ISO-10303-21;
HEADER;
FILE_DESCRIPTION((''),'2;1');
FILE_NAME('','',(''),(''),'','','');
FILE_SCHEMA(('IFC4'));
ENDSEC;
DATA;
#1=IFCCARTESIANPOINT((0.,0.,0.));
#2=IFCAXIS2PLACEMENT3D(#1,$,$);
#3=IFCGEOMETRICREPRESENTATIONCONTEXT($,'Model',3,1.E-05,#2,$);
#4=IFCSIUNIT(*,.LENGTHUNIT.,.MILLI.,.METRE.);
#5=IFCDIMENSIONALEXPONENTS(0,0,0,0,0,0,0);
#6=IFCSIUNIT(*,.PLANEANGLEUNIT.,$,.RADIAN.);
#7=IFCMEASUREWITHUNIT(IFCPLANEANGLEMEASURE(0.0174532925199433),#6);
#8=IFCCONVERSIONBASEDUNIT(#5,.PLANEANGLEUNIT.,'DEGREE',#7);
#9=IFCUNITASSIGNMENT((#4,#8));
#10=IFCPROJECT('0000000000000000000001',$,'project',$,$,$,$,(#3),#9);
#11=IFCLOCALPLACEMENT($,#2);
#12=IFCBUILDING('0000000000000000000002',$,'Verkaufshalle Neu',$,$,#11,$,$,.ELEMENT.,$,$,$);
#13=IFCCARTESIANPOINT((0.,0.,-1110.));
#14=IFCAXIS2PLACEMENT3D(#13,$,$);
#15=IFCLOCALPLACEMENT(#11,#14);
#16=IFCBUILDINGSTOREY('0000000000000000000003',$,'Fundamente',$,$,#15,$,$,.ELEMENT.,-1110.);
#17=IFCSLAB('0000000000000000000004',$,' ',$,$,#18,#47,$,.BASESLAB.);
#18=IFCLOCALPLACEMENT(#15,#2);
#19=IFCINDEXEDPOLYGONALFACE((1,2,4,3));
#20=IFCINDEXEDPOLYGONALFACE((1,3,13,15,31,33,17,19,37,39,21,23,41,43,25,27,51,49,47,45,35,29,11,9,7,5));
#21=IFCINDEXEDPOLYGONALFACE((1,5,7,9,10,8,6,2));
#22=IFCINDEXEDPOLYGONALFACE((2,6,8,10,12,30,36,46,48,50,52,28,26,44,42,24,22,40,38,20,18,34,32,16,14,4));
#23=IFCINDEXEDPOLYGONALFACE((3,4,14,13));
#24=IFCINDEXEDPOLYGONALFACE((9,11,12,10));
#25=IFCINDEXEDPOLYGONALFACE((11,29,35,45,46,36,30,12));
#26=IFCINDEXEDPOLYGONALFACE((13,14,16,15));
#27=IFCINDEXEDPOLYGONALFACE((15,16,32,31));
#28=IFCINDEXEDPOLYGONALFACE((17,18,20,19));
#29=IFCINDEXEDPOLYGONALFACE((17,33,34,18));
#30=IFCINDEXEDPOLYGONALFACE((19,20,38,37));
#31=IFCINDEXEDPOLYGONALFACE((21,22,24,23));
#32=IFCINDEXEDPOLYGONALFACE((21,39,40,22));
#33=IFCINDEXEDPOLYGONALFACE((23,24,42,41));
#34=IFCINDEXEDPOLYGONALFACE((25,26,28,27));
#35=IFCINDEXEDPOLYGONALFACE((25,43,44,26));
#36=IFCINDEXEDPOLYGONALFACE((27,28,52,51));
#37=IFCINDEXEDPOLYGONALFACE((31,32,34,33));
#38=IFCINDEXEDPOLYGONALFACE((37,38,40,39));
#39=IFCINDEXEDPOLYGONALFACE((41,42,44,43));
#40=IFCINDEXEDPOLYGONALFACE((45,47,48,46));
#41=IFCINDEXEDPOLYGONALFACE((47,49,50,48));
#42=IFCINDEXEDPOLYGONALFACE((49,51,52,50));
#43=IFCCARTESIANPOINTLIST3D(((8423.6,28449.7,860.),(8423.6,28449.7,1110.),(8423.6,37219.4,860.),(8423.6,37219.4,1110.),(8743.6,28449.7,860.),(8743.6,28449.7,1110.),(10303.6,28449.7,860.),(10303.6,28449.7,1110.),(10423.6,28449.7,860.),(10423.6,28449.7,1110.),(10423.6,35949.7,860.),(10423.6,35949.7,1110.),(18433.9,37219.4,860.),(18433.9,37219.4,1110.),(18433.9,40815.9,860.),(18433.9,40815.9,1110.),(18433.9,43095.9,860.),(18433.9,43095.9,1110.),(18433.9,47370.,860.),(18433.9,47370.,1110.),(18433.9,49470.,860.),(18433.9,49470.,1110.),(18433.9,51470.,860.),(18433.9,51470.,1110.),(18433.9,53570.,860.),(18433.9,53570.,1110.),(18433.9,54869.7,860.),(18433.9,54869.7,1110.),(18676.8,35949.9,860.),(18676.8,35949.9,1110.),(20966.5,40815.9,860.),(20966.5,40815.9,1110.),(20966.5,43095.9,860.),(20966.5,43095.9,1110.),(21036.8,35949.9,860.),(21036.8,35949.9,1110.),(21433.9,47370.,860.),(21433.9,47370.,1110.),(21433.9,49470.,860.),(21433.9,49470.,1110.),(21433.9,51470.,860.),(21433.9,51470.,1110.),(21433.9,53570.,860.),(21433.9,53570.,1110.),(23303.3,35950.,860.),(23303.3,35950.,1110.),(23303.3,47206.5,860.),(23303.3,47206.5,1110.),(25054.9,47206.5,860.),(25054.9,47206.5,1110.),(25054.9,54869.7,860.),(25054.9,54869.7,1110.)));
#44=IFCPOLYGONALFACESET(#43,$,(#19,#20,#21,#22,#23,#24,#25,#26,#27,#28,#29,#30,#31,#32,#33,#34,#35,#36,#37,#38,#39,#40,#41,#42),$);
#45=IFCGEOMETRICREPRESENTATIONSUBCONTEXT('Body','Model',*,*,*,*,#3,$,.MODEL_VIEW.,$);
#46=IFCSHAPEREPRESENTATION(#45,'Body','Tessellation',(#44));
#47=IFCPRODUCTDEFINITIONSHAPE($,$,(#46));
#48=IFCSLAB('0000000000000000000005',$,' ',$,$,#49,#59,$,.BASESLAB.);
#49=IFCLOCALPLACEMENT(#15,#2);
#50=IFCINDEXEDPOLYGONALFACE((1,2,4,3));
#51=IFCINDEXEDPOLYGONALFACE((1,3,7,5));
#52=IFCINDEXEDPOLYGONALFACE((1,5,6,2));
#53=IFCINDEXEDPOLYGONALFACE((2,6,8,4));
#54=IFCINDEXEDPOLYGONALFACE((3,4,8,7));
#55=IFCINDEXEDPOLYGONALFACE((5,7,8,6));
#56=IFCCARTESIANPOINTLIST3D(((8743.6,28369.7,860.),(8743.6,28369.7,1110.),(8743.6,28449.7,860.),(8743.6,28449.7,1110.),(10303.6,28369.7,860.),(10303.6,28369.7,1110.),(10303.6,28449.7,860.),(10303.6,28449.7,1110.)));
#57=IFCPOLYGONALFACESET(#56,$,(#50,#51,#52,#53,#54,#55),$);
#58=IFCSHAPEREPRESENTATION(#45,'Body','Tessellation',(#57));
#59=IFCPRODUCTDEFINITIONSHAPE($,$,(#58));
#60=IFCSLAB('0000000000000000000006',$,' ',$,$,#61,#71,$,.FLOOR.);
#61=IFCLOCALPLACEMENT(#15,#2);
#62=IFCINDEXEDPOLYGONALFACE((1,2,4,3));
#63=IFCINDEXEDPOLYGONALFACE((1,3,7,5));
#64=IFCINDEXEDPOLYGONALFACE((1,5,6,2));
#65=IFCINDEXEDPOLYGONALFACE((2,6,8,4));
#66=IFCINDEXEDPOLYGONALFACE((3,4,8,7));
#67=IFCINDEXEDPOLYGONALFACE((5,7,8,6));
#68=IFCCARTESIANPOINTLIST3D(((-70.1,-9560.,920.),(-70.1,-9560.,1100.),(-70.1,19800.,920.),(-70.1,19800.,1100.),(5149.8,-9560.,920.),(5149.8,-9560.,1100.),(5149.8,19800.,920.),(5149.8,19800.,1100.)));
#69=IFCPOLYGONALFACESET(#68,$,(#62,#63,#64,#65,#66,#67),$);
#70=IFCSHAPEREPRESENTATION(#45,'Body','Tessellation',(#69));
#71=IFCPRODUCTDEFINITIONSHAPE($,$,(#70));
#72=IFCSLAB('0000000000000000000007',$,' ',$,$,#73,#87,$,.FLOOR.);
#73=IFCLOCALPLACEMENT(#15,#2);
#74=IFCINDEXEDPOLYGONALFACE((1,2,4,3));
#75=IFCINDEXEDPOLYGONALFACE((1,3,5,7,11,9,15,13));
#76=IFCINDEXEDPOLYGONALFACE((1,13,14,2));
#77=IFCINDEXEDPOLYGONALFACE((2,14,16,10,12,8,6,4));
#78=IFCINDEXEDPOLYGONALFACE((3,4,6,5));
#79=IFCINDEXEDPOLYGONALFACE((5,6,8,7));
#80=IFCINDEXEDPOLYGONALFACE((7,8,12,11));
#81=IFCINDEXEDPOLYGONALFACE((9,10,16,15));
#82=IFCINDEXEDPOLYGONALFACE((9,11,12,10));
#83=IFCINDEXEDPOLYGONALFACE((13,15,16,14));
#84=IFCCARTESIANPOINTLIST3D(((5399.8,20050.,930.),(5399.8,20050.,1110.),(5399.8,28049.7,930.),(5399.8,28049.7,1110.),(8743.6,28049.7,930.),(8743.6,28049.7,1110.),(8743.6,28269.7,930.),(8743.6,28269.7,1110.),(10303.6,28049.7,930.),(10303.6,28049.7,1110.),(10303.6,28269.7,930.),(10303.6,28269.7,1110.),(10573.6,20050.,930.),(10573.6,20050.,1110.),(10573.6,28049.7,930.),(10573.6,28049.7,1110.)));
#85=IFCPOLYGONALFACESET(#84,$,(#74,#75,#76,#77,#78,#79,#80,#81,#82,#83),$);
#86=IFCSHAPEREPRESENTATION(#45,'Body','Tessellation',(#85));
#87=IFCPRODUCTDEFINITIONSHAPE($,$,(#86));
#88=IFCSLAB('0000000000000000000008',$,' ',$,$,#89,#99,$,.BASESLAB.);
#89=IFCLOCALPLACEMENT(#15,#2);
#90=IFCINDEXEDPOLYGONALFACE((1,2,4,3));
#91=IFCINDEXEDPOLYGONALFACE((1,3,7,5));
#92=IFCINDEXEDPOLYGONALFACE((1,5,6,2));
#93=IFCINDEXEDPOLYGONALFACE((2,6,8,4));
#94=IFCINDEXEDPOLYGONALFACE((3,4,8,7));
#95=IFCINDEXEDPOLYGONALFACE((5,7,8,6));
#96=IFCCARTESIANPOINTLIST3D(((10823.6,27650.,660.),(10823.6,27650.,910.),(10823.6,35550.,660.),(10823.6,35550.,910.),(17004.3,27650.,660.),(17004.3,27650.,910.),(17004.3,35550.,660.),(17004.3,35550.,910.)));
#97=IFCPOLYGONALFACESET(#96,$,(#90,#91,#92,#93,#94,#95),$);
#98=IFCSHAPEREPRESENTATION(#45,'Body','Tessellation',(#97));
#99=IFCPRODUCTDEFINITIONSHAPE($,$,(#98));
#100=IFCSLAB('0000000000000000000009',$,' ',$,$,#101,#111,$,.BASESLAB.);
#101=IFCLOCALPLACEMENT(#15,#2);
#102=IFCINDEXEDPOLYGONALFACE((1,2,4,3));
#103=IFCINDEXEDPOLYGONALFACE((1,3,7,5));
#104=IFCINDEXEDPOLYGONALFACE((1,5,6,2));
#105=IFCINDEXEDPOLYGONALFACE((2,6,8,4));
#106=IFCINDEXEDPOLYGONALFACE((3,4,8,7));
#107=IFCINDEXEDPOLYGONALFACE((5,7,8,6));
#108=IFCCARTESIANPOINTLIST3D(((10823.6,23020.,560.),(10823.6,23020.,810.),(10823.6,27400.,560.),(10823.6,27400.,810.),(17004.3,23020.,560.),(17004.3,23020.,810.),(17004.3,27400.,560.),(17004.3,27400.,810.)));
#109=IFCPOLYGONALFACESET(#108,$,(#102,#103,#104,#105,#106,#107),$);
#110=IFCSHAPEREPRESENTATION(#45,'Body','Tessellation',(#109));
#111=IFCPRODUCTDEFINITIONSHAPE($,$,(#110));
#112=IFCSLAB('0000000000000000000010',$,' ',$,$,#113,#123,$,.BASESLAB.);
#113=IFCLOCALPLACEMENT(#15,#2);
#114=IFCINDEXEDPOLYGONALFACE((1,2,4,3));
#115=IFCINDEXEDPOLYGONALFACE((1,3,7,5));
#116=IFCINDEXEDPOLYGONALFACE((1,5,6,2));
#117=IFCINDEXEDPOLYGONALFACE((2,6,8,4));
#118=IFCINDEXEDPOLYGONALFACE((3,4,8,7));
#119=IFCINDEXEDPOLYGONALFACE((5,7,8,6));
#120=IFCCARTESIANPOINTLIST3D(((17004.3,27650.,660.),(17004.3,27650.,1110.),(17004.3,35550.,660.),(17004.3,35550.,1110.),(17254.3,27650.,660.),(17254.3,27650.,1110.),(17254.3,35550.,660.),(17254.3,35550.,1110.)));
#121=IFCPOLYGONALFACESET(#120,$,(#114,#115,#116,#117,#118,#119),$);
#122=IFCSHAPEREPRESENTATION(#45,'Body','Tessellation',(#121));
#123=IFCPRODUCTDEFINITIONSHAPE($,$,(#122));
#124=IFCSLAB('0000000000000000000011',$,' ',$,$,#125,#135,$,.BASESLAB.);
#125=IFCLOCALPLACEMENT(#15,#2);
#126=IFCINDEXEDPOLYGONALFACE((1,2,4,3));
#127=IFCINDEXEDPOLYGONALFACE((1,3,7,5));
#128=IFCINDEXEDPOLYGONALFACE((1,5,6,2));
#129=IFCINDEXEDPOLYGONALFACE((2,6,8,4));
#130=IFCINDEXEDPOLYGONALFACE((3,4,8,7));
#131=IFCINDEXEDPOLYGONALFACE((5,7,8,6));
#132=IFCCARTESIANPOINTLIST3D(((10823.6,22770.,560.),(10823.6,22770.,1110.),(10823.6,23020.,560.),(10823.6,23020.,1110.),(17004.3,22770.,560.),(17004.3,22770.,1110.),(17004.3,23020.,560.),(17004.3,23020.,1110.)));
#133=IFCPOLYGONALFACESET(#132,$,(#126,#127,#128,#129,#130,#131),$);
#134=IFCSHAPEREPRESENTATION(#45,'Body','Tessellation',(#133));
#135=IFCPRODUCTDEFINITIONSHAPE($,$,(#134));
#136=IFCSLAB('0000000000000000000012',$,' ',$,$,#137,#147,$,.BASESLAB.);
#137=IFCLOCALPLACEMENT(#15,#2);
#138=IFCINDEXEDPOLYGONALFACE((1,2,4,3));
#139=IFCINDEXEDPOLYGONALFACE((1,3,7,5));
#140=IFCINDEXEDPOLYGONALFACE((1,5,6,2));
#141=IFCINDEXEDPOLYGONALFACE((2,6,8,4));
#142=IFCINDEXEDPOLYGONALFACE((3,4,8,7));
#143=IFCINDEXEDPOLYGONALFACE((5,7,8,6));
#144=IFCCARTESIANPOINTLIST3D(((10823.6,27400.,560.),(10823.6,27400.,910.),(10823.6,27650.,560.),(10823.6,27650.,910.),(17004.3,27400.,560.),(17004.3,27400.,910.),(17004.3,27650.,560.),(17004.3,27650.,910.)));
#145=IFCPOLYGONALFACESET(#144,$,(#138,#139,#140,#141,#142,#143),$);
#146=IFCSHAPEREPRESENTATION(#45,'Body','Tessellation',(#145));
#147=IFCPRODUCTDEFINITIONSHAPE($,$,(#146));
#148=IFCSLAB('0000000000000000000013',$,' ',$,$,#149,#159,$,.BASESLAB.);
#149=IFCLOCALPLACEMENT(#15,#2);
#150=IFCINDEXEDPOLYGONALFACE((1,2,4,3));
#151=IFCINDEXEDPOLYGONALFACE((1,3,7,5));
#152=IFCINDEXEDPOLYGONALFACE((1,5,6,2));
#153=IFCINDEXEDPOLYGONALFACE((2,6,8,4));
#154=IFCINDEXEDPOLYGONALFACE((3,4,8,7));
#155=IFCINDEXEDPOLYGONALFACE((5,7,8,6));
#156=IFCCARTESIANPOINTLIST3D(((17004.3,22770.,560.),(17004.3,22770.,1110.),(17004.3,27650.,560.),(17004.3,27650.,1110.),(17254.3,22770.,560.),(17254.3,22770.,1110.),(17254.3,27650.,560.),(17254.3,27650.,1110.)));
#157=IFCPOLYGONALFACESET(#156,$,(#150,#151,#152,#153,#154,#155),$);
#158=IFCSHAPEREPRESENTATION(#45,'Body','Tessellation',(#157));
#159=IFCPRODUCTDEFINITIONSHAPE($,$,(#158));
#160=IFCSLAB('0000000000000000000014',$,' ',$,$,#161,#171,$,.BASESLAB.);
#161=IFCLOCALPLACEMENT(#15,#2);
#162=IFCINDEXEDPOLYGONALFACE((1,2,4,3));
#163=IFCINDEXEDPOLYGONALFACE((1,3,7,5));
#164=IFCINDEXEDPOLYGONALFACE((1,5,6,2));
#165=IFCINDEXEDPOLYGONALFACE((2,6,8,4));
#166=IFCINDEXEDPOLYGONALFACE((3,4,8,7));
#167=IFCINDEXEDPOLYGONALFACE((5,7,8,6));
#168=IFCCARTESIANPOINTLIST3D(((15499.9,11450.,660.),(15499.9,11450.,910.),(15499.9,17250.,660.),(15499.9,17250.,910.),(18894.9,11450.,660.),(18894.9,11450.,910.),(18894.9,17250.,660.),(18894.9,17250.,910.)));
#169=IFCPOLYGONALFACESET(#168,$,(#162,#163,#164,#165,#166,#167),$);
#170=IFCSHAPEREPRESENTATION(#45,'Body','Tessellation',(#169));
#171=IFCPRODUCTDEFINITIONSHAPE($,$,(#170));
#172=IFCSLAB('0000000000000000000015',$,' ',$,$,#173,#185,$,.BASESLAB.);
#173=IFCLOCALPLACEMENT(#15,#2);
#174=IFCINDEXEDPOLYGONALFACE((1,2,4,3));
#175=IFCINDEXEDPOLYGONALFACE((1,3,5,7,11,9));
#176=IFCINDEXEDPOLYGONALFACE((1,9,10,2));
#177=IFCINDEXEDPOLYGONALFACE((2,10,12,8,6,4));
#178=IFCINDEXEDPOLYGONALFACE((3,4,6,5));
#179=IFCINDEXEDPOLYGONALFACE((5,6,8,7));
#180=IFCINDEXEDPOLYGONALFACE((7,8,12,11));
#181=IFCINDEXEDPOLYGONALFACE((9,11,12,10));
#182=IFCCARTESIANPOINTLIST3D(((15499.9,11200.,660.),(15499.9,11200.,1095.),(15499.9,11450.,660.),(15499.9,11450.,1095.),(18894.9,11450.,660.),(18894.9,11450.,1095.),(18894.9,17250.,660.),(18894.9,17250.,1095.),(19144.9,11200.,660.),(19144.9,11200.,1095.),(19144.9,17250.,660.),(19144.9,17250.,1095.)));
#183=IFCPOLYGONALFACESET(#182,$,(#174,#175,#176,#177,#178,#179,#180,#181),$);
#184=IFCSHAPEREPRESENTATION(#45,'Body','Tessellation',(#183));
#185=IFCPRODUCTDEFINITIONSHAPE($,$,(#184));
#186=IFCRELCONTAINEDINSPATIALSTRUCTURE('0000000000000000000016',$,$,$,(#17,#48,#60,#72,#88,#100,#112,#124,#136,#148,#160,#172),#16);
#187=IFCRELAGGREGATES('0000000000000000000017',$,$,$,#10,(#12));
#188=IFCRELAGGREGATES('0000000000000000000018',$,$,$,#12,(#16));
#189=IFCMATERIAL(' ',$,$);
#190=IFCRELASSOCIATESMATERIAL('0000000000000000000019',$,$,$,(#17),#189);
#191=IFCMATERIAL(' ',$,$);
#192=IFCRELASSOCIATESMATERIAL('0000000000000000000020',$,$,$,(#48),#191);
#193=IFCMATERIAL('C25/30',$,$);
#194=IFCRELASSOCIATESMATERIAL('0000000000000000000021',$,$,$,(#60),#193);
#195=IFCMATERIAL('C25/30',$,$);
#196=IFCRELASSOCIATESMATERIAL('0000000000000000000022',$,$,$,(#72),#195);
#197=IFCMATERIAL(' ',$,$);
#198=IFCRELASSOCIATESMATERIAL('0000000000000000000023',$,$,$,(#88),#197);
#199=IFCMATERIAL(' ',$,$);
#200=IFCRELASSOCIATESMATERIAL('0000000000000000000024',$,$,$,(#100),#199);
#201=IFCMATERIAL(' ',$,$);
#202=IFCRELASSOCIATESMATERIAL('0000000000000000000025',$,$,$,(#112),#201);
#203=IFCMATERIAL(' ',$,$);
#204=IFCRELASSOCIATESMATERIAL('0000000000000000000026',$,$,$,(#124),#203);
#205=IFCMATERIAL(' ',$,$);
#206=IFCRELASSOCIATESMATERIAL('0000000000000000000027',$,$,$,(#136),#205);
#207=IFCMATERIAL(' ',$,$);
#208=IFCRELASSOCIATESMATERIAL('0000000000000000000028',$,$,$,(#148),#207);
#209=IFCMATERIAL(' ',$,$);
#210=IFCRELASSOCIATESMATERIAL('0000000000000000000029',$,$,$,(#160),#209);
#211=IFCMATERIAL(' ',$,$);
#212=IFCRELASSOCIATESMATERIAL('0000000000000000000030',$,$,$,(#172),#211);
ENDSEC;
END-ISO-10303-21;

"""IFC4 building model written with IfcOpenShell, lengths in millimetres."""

from ifc_helpers import new_model, entity, si_unit, converted_unit, frame, frame_2d, origin, origin_with_axes, place, context, subcontext, project, spatial, polyline, rectangle, outline, extrude, material, element, save


model = new_model("IFC4")

# Units and contexts
model_context = context("Model", 3, precision=1e-05, world=origin())
body_context = subcontext(model_context, "Body", "Model", "MODEL_VIEW")
ifc_project = project(units=[si_unit("LENGTHUNIT", "METRE", prefix="MILLI"), converted_unit("PLANEANGLEUNIT", "DEGREE", entity("IfcPlaneAngleMeasure", 0.0174532925199433), si_unit("PLANEANGLEUNIT", "RADIAN"), dimensions=[0, 0, 0, 0, 0, 0, 0])], contexts=[model_context])

# Building, storey
building_placement = place(None, origin())
building = spatial("IfcBuilding", under=ifc_project, at=building_placement, Name="Verkaufshalle Neu", CompositionType="ELEMENT")
storey_placement = place(building_placement, frame((0.0, 0.0, -1110.0)))
storey = spatial("IfcBuildingStorey", under=building, at=storey_placement, Name="Fundamente", CompositionType="ELEMENT", Elevation=-1110.0)

# Slabs
ifc_material_1 = material(Name=" ")
slab_1_placement = place(storey_placement, frame((8423.6, 28449.7, 860.0)))
element("IfcSlab", 1, at=slab_1_placement, inside=storey, material=ifc_material_1, Name=" ", PredefinedType="BASESLAB", context=body_context, shape_type="SweptSolid", body=[
    extrude(outline(polyline([(0.0, 0.0), (320.0, 0.0), (1880.0, 0.0), (2000.0, 0.0), (2000.0, 7500.0), (10253.2, 7500.2), (10253.2, 7500.2), (12613.2, 7500.2), (14879.6, 7500.3), (14879.6, 18756.8), (16631.3, 18756.8), (16631.3, 26420.0), (10010.3, 26420.0), (10010.3, 25120.3), (13010.3, 25120.3), (13010.3, 23020.3), (10010.3, 23020.3), (10010.3, 21020.3), (13010.3, 21020.3), (13010.3, 18920.3), (10010.3, 18920.3), (10010.3, 14646.2), (12542.9, 14646.2), (12542.9, 12366.2), (10010.3, 12366.2), (10010.3, 8769.7), (0.0, 8769.7), (0.0, 0.0)])), origin_with_axes(), (0.0, 0.0, 1.0), 250.0),
])
ifc_material_2 = material(Name=" ")
slab_2_placement = place(storey_placement, frame((8743.6, 28369.7, 860.0)))
element("IfcSlab", 2, at=slab_2_placement, inside=storey, material=ifc_material_2, Name=" ", PredefinedType="BASESLAB", context=body_context, shape_type="SweptSolid", body=[
    extrude(rectangle(XDim=1560.0, YDim=80.0, at=frame_2d((780.0, 40.0), x_axis=(1.0, 0.0))), origin_with_axes(), (0.0, 0.0, 1.0), 250.0),
])
ifc_material_3 = material(Name="C25/30")
slab_3_placement = place(storey_placement, frame((-70.1, -9560.0, 920.0)))
element("IfcSlab", 3, at=slab_3_placement, inside=storey, material=ifc_material_3, Name=" ", PredefinedType="FLOOR", context=body_context, shape_type="SweptSolid", body=[
    extrude(rectangle(XDim=29360.0, YDim=5219.8, at=frame_2d((2609.9, -14680.0), x_axis=(0.0, -1.0))), frame((0.0, 29360.0, 0.0), z_axis=(0.0, 0.0, 1.0), x_axis=(1.0, 0.0, 0.0)), (0.0, 0.0, 1.0), 180.0),
])
ifc_material_4 = material(Name="C25/30")
slab_4_placement = place(storey_placement, frame((5399.8, 20050.0, 930.0)))
element("IfcSlab", 4, at=slab_4_placement, inside=storey, material=ifc_material_4, Name=" ", PredefinedType="FLOOR", context=body_context, shape_type="SweptSolid", body=[
    extrude(outline(polyline([(0.0, 0.0), (5173.9, 0.0), (5173.9, 7999.7), (4903.9, 7999.7), (4903.9, 8219.7), (3343.9, 8219.7), (3343.9, 7999.7), (0.0, 7999.7), (0.0, 0.0)])), origin_with_axes(), (0.0, 0.0, 1.0), 180.0),
])
ifc_material_5 = material(Name=" ")
slab_5_placement = place(storey_placement, frame((10823.6, 27650.0, 660.0)))
element("IfcSlab", 5, at=slab_5_placement, inside=storey, material=ifc_material_5, Name=" ", PredefinedType="BASESLAB", context=body_context, shape_type="SweptSolid", body=[
    extrude(rectangle(XDim=7900.0, YDim=6180.7, at=frame_2d((-3090.4, 3950.0), x_axis=(0.0, 1.0))), frame((6180.7, 0.0, 0.0), z_axis=(0.0, 0.0, 1.0), x_axis=(1.0, 0.0, 0.0)), (0.0, 0.0, 1.0), 250.0),
])
ifc_material_6 = material(Name=" ")
slab_6_placement = place(storey_placement, frame((10823.6, 23020.0, 560.0)))
element("IfcSlab", 6, at=slab_6_placement, inside=storey, material=ifc_material_6, Name=" ", PredefinedType="BASESLAB", context=body_context, shape_type="SweptSolid", body=[
    extrude(rectangle(XDim=4380.0, YDim=6180.7, at=frame_2d((3090.4, -2190.0), x_axis=(0.0, -1.0))), frame((0.0, 4380.0, 0.0), z_axis=(0.0, 0.0, 1.0), x_axis=(1.0, 0.0, 0.0)), (0.0, 0.0, 1.0), 250.0),
])
ifc_material_7 = material(Name=" ")
slab_7_placement = place(storey_placement, frame((17004.3, 27650.0, 660.0)))
element("IfcSlab", 7, at=slab_7_placement, inside=storey, material=ifc_material_7, Name=" ", PredefinedType="BASESLAB", context=body_context, shape_type="SweptSolid", body=[
    extrude(rectangle(XDim=250.0, YDim=7900.0, at=frame_2d((-125.0, -3950.0), x_axis=(-1.0, 0.0))), frame((250.0, 7900.0, 0.0), z_axis=(0.0, 0.0, 1.0), x_axis=(1.0, 0.0, 0.0)), (0.0, 0.0, 1.0), 450.0),
])
ifc_material_8 = material(Name=" ")
slab_8_placement = place(storey_placement, frame((10823.6, 22770.0, 560.0)))
element("IfcSlab", 8, at=slab_8_placement, inside=storey, material=ifc_material_8, Name=" ", PredefinedType="BASESLAB", context=body_context, shape_type="SweptSolid", body=[
    extrude(rectangle(XDim=250.0, YDim=6180.7, at=frame_2d((-3090.4, 125.0), x_axis=(0.0, 1.0))), frame((6180.7, 0.0, 0.0), z_axis=(0.0, 0.0, 1.0), x_axis=(1.0, 0.0, 0.0)), (0.0, 0.0, 1.0), 550.0),
])
ifc_material_9 = material(Name=" ")
slab_9_placement = place(storey_placement, frame((10823.6, 27400.0, 560.0)))
element("IfcSlab", 9, at=slab_9_placement, inside=storey, material=ifc_material_9, Name=" ", PredefinedType="BASESLAB", context=body_context, shape_type="SweptSolid", body=[
    extrude(rectangle(XDim=250.0, YDim=6180.7, at=frame_2d((3090.4, -125.0), x_axis=(0.0, -1.0))), frame((0.0, 250.0, 0.0), z_axis=(0.0, 0.0, 1.0), x_axis=(1.0, 0.0, 0.0)), (0.0, 0.0, 1.0), 350.0),
])
ifc_material_10 = material(Name=" ")
slab_10_placement = place(storey_placement, frame((17004.3, 22770.0, 560.0)))
element("IfcSlab", 10, at=slab_10_placement, inside=storey, material=ifc_material_10, Name=" ", PredefinedType="BASESLAB", context=body_context, shape_type="SweptSolid", body=[
    extrude(rectangle(XDim=4880.0, YDim=250.0, at=frame_2d((125.0, -2440.0), x_axis=(0.0, -1.0))), frame((0.0, 4880.0, 0.0), z_axis=(0.0, 0.0, 1.0), x_axis=(1.0, 0.0, 0.0)), (0.0, 0.0, 1.0), 550.0),
])
ifc_material_11 = material(Name=" ")
slab_11_placement = place(storey_placement, frame((15499.9, 11450.0, 660.0)))
element("IfcSlab", 11, at=slab_11_placement, inside=storey, material=ifc_material_11, Name=" ", PredefinedType="BASESLAB", context=body_context, shape_type="SweptSolid", body=[
    extrude(rectangle(XDim=5800.0, YDim=3395.0, at=frame_2d((1697.5, -2900.0), x_axis=(0.0, -1.0))), frame((0.0, 5800.0, 0.0), z_axis=(0.0, 0.0, 1.0), x_axis=(1.0, 0.0, 0.0)), (0.0, 0.0, 1.0), 250.0),
])
ifc_material_12 = material(Name=" ")
slab_12_placement = place(storey_placement, frame((15499.9, 11200.0, 660.0)))
element("IfcSlab", 12, at=slab_12_placement, inside=storey, material=ifc_material_12, Name=" ", PredefinedType="BASESLAB", context=body_context, shape_type="SweptSolid", body=[
    extrude(outline(polyline([(3395.0, 6050.0), (3395.0, 250.0), (0.0, 250.0), (0.0, 0.0), (3645.0, 0.0), (3645.0, 6050.0), (3395.0, 6050.0)])), origin_with_axes(), (0.0, 0.0, 1.0), 435.0),
])

save(model, "model.ifc")
